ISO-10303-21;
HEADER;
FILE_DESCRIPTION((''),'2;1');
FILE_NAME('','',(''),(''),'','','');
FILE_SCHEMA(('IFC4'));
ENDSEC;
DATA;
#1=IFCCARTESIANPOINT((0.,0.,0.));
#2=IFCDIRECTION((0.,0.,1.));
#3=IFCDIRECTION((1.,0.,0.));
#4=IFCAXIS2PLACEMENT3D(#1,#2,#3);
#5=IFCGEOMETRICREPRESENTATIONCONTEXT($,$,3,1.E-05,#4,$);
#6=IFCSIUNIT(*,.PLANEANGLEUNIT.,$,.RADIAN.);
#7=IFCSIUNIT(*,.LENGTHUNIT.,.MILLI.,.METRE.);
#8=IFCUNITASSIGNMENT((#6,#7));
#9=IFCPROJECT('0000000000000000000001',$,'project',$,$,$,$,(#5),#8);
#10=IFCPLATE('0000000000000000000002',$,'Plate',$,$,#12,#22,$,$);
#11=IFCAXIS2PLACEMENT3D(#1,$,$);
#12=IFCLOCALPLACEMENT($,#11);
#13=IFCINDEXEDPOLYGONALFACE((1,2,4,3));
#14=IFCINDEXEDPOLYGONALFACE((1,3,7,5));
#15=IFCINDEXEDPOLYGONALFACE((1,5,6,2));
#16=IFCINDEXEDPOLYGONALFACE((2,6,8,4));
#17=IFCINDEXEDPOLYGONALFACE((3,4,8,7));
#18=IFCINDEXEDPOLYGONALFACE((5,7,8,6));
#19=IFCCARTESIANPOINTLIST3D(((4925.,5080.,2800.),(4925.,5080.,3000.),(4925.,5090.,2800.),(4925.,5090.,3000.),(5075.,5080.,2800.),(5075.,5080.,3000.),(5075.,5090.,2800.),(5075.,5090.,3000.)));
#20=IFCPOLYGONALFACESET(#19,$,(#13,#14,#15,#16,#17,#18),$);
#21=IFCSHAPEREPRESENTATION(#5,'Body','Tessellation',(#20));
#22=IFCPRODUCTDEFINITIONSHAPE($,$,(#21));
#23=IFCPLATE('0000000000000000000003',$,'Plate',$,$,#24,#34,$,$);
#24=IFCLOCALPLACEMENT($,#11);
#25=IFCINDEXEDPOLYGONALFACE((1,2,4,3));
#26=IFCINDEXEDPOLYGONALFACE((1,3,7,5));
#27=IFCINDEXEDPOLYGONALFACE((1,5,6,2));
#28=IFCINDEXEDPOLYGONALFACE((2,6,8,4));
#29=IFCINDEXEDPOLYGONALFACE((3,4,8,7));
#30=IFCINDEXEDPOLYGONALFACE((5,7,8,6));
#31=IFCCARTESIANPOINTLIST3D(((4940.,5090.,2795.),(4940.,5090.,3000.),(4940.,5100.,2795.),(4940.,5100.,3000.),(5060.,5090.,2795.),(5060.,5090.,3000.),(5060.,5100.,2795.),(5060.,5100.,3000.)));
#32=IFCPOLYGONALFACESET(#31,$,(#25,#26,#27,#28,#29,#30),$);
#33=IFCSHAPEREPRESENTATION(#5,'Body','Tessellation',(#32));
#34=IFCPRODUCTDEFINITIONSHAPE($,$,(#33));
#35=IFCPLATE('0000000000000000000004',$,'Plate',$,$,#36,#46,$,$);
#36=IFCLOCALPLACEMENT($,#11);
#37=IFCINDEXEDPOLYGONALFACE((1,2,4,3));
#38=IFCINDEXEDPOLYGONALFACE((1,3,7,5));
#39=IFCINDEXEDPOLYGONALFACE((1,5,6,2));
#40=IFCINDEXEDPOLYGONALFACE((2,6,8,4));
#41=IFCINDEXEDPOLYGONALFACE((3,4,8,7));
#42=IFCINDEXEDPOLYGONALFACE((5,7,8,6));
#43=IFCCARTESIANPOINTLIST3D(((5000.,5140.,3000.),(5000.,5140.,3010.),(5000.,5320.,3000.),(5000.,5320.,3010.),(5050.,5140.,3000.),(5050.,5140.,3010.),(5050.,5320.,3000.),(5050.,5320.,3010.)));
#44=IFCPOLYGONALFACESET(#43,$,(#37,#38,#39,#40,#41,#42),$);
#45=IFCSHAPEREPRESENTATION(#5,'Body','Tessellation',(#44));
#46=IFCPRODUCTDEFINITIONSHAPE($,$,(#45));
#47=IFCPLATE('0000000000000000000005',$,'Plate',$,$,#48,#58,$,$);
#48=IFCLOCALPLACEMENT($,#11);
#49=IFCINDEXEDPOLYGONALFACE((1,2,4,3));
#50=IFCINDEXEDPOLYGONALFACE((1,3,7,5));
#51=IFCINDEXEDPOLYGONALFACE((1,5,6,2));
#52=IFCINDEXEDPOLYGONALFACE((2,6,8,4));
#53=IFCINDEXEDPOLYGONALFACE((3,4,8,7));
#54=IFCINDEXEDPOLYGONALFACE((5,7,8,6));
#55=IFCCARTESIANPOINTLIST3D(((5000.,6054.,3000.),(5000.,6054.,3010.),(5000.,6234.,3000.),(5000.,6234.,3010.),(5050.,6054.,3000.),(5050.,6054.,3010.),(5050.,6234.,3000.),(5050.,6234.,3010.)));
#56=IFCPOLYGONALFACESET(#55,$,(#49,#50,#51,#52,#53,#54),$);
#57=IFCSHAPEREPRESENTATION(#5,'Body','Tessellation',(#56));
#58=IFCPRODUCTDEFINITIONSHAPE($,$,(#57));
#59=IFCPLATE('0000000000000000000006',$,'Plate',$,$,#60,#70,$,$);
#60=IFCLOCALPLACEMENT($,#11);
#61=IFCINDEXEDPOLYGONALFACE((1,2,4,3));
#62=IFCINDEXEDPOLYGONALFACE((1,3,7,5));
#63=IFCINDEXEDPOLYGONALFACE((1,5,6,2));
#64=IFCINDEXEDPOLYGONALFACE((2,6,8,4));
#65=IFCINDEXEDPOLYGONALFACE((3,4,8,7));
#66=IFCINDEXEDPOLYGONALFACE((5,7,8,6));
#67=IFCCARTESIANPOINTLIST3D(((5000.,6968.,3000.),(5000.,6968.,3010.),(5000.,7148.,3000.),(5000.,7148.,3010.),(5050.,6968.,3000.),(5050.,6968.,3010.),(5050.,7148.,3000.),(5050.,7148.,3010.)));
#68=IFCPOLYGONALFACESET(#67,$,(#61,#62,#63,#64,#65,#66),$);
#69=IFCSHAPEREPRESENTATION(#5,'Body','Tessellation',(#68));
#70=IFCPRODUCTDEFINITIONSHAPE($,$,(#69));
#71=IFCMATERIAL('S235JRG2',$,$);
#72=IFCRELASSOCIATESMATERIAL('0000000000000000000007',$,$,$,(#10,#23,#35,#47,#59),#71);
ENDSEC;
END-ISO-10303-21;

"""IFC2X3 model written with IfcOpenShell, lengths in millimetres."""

from ifc_helpers import new_model, si_unit, frame, origin_with_axes, place, context, project, polyline, outline, extrude, material, element, save


model = new_model("IFC2X3")

# Units and contexts
context_of_model = context(None, 3, precision=1e-05, world=origin_with_axes())
ifc_project = project(units=[si_unit("PLANEANGLEUNIT", "RADIAN"), si_unit("LENGTHUNIT", "METRE", prefix="MILLI")], contexts=[context_of_model])

# Shared definitions
ifc_material = material(Name="S235JRG2")

# Plates
placement_1 = place(None, origin_with_axes())
plate_1_placement = place(placement_1, frame((4925.0, 5080.0, 3000.0), z_axis=(0.0, 0.0, -1.0), x_axis=(0.0, 1.0, 0.0)))
element("IfcPlate", 1, at=plate_1_placement, material=ifc_material, Name="Plate", context=context_of_model, shape_type="SweptSolid", body=[
    extrude(outline(polyline([(0.0, 0.0), (150.0, 0.0), (150.0, 200.0), (0.0, 200.0), (0.0, 0.0)])), frame((0.0, 0.0, 0.0), z_axis=(1.0, 0.0, 0.0), x_axis=(0.0, 1.0, 0.0)), (0.0, 0.0, 1.0), 10.0),
])
placement_2 = place(None, origin_with_axes())
plate_2_placement = place(placement_2, frame((5060.0, 5100.0, 3000.0), z_axis=(0.0, 0.0, -1.0), x_axis=(0.0, -1.0, 0.0)))
element("IfcPlate", 2, at=plate_2_placement, material=ifc_material, Name="Plate", context=context_of_model, shape_type="SweptSolid", body=[
    extrude(outline(polyline([(0.0, 0.0), (120.0, 0.0), (120.0, 205.0), (0.0, 205.0), (0.0, 0.0)])), frame((0.0, 0.0, 0.0), z_axis=(1.0, 0.0, 0.0), x_axis=(0.0, 1.0, 0.0)), (0.0, 0.0, 1.0), 10.0),
])
placement_3 = place(None, origin_with_axes())
plate_3_placement = place(placement_3, frame((5000.0, 5140.0, 3010.0), z_axis=(1.0, 0.0, 0.0), x_axis=(0.0, 0.0, -1.0)))
element("IfcPlate", 3, at=plate_3_placement, material=ifc_material, Name="Plate", context=context_of_model, shape_type="SweptSolid", body=[
    extrude(outline(polyline([(0.0, 0.0), (180.0, 0.0), (180.0, 50.0), (0.0, 50.0), (0.0, 0.0)])), frame((0.0, 0.0, 0.0), z_axis=(1.0, 0.0, 0.0), x_axis=(0.0, 1.0, 0.0)), (0.0, 0.0, 1.0), 10.0),
])
placement_4 = place(None, origin_with_axes())
plate_4_placement = place(placement_4, frame((5000.0, 6054.0, 3010.0), z_axis=(1.0, 0.0, 0.0), x_axis=(0.0, 0.0, -1.0)))
element("IfcPlate", 4, at=plate_4_placement, material=ifc_material, Name="Plate", context=context_of_model, shape_type="SweptSolid", body=[
    extrude(outline(polyline([(0.0, 0.0), (180.0, 0.0), (180.0, 50.0), (0.0, 50.0), (0.0, 0.0)])), frame((0.0, 0.0, 0.0), z_axis=(1.0, 0.0, 0.0), x_axis=(0.0, 1.0, 0.0)), (0.0, 0.0, 1.0), 10.0),
])
placement_5 = place(None, origin_with_axes())
plate_5_placement = place(placement_5, frame((5000.0, 6968.0, 3010.0), z_axis=(1.0, 0.0, 0.0), x_axis=(0.0, 0.0, -1.0)))
element("IfcPlate", 5, at=plate_5_placement, material=ifc_material, Name="Plate", context=context_of_model, shape_type="SweptSolid", body=[
    extrude(outline(polyline([(0.0, 0.0), (180.0, 0.0), (180.0, 50.0), (0.0, 50.0), (0.0, 0.0)])), frame((0.0, 0.0, 0.0), z_axis=(1.0, 0.0, 0.0), x_axis=(0.0, 1.0, 0.0)), (0.0, 0.0, 1.0), 10.0),
])

save(model, "model.ifc")
